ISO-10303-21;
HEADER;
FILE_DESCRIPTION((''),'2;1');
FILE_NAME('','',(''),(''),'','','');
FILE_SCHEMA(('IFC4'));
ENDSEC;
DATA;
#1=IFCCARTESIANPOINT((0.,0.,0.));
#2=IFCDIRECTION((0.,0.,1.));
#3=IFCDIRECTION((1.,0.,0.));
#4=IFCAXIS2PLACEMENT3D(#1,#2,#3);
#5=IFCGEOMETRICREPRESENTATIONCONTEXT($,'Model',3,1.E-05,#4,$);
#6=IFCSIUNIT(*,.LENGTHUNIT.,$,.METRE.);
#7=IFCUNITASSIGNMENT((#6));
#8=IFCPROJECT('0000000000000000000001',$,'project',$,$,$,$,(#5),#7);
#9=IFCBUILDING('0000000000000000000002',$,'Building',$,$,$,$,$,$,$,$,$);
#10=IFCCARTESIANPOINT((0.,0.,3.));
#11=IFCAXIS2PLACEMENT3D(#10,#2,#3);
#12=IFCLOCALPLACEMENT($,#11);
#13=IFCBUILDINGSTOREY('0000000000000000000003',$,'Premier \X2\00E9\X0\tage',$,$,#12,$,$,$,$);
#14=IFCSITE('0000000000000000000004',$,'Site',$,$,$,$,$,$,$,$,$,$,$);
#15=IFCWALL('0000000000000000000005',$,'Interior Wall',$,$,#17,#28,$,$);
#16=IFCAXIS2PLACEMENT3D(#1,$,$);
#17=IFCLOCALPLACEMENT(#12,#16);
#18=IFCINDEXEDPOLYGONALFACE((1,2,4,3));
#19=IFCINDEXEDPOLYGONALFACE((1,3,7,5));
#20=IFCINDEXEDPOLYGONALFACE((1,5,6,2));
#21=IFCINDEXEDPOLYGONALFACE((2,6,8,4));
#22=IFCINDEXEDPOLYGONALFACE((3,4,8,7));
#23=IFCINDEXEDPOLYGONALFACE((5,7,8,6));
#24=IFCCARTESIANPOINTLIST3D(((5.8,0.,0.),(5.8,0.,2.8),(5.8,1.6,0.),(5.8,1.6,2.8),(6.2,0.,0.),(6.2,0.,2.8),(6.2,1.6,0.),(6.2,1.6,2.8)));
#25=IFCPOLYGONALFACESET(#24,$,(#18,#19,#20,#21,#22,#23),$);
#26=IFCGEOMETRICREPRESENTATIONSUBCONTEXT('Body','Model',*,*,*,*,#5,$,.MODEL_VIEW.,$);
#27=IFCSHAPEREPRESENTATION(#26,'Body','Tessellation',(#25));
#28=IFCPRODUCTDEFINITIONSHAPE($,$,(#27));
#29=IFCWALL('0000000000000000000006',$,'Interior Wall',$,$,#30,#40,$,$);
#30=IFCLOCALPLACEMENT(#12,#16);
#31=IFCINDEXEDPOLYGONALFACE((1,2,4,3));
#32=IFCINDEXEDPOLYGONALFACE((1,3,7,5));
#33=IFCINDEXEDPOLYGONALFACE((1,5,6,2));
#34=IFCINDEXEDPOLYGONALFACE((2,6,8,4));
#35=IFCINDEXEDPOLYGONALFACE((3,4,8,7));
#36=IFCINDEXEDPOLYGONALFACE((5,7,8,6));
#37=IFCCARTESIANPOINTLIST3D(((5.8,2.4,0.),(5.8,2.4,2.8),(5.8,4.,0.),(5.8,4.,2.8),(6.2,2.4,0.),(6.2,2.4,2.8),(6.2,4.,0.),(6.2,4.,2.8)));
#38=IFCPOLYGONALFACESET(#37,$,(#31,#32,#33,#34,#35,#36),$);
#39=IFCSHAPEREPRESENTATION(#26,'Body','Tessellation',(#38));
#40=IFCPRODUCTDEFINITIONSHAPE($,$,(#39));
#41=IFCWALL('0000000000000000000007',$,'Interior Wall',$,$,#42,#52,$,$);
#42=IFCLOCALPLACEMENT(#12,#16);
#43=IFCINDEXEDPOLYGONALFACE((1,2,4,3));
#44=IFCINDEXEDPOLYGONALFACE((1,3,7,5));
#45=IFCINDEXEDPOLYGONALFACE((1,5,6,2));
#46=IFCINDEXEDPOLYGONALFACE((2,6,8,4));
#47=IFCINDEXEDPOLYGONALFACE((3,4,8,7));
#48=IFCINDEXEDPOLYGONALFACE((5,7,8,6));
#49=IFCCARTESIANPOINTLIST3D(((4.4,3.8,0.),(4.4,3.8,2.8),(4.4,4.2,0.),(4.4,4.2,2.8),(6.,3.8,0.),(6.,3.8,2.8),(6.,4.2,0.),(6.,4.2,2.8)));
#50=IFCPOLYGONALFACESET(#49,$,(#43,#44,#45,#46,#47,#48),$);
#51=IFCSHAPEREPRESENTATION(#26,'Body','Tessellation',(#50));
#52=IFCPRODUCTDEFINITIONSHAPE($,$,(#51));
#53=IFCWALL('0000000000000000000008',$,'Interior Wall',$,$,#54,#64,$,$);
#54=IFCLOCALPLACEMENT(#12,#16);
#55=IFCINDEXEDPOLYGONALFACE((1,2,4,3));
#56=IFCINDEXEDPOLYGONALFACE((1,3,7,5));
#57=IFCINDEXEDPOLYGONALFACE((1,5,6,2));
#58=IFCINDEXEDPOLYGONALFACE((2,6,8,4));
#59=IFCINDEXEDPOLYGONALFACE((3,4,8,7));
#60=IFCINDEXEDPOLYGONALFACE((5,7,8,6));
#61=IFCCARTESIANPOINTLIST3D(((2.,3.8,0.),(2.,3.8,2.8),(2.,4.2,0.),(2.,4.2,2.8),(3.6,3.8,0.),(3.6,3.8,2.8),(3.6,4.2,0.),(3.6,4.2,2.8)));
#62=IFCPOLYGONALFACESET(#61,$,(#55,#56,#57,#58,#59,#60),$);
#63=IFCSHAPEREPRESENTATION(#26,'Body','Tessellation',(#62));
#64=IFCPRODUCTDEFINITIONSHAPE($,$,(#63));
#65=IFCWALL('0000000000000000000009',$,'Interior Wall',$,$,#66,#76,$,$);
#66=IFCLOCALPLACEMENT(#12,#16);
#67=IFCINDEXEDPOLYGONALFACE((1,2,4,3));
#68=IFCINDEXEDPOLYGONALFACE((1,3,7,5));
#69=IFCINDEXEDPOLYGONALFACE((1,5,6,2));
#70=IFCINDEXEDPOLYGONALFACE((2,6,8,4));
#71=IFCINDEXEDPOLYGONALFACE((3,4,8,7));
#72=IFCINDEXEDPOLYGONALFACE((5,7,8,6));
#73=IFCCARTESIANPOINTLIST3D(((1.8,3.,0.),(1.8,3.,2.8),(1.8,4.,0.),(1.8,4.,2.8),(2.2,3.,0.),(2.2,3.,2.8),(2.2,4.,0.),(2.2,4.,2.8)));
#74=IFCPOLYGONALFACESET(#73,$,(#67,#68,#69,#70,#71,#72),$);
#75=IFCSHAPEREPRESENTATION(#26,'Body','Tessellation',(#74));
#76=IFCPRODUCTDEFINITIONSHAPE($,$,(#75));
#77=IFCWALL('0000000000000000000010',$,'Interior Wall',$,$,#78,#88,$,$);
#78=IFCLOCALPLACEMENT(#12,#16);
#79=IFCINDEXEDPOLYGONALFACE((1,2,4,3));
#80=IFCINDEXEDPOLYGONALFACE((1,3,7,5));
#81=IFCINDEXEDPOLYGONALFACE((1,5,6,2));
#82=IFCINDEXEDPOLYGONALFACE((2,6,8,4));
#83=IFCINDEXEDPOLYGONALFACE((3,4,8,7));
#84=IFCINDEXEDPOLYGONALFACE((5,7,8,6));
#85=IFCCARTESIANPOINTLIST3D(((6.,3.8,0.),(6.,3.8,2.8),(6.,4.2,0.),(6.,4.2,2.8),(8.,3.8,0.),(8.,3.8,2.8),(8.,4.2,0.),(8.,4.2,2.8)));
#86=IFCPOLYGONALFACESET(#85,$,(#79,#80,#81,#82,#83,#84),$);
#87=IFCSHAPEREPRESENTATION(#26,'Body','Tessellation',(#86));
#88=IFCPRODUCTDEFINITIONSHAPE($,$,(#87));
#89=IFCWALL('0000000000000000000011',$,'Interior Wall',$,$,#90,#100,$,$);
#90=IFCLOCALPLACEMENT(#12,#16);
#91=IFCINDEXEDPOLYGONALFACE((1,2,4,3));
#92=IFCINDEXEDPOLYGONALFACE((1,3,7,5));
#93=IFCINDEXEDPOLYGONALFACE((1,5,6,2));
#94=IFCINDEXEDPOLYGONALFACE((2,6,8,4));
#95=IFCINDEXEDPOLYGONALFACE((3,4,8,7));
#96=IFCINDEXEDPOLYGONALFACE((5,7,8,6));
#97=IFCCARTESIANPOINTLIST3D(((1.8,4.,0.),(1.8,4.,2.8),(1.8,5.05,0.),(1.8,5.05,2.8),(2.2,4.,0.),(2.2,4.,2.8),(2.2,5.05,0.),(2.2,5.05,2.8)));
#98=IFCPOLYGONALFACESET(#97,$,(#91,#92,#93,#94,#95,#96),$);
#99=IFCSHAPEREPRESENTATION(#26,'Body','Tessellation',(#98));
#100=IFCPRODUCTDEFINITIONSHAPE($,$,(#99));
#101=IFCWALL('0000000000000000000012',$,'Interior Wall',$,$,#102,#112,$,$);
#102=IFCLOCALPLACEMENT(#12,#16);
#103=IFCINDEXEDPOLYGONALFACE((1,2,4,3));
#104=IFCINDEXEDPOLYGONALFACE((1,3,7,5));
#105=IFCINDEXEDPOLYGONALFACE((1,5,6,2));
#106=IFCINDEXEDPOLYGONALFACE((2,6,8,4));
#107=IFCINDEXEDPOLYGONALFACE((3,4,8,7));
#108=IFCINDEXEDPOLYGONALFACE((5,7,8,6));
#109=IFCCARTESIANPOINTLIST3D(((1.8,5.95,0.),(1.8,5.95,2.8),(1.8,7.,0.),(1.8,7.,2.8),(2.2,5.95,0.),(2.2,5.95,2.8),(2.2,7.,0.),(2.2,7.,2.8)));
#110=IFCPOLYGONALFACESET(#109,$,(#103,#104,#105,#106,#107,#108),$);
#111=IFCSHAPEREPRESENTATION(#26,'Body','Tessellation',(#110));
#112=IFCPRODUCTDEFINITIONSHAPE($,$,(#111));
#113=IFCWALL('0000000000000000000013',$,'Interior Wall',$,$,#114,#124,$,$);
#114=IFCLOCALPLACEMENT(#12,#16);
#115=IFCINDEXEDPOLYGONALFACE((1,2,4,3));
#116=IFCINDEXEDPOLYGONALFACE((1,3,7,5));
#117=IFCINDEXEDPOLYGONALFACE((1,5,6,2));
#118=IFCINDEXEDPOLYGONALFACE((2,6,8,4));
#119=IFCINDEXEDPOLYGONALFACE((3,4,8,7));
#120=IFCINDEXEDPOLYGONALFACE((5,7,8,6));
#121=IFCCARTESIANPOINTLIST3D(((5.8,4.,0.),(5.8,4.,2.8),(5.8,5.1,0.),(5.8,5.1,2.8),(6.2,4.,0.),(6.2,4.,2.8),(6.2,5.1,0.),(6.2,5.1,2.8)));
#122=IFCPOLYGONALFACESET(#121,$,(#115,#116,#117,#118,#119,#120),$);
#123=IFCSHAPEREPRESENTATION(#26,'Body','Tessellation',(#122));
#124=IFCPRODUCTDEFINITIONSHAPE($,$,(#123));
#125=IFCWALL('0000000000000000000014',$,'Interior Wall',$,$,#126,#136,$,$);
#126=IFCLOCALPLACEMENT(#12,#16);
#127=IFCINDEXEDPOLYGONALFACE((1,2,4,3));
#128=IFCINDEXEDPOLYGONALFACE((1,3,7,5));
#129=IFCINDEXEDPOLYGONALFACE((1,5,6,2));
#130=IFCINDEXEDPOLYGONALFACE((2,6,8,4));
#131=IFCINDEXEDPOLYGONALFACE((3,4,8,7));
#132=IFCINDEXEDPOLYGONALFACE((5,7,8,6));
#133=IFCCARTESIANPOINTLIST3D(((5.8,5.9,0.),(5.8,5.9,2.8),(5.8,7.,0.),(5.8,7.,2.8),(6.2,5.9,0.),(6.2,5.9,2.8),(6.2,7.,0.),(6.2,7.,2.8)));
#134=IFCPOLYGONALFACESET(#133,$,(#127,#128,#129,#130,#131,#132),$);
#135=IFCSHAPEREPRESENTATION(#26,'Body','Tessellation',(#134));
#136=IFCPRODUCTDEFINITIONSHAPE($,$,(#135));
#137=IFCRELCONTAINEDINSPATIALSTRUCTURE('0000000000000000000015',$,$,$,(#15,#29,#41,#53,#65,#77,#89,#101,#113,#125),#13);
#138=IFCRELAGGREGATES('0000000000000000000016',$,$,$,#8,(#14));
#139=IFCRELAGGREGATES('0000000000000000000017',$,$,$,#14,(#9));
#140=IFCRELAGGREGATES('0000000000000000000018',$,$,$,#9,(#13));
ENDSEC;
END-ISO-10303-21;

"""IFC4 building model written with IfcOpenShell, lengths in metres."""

from ifc_helpers import new_model, si_unit, frame, origin_with_axes, place, context, subcontext, project, spatial, indexed_curve, outline, extrude, element, save


model = new_model("IFC4")

# Units and contexts
model_context = context("Model", 3, precision=1e-05, world=origin_with_axes())
body_context = subcontext(model_context, "Body", "Model", "MODEL_VIEW")
ifc_project = project(units=[si_unit("LENGTHUNIT", "METRE")], contexts=[model_context])

# Site, building, storey
site = spatial("IfcSite", under=ifc_project, Name="Site")
building = spatial("IfcBuilding", under=site, Name="Building")
storey_placement = place(None, frame((0.0, 0.0, 3.0), z_axis=(0.0, 0.0, 1.0), x_axis=(1.0, 0.0, 0.0)))
storey = spatial("IfcBuildingStorey", under=building, at=storey_placement, Name="Premier étage")

# Walls
for number, where, z_axis, x_axis, name in (
    (1, (6.0, 0.0, 0.0), (0.0, 0.0, 1.0), (0.0, 1.0, 0.0), "Interior Wall"),
    (2, (6.0, 2.4, 0.0), (0.0, 0.0, 1.0), (0.0, 1.0, 0.0), "Interior Wall"),
):
    element("IfcWall", number, at=place(storey_placement, frame(where, z_axis=z_axis, x_axis=x_axis)), inside=storey, Name=name, context=body_context, shape_type="SweptSolid", body=[
        extrude(outline(indexed_curve([(0.0, 0.0), (0.0, 0.4), (1.6, 0.4), (1.6, 0.0), (0.0, 0.0)], self_intersect=False)), frame((0.0, -0.2, 0.0), z_axis=(0.0, 0.0, 1.0), x_axis=(1.0, 0.0, 0.0)), (0.0, 0.0, 1.0), 2.8),
    ])
wall_1_placement = place(storey_placement, frame((6.0, 4.0, 0.0), z_axis=(0.0, 0.0, 1.0), x_axis=(-1.0, 0.0, 0.0)))
element("IfcWall", 3, at=wall_1_placement, inside=storey, Name="Interior Wall", context=body_context, shape_type="SweptSolid", body=[
    extrude(outline(indexed_curve([(0.0, 0.0), (0.0, 0.4), (1.6, 0.4), (1.6, 0.0), (0.0, 0.0)], self_intersect=False)), frame((0.0, -0.2, 0.0), z_axis=(0.0, 0.0, 1.0), x_axis=(1.0, 0.0, 0.0)), (0.0, 0.0, 1.0), 2.8),
])
wall_2_placement = place(storey_placement, frame((3.6, 4.0, 0.0), z_axis=(0.0, 0.0, 1.0), x_axis=(-1.0, 0.0, 0.0)))
element("IfcWall", 4, at=wall_2_placement, inside=storey, Name="Interior Wall", context=body_context, shape_type="SweptSolid", body=[
    extrude(outline(indexed_curve([(0.0, 0.0), (0.0, 0.4), (1.6, 0.4), (1.6, 0.0), (0.0, 0.0)], self_intersect=False)), frame((0.0, -0.2, 0.0), z_axis=(0.0, 0.0, 1.0), x_axis=(1.0, 0.0, 0.0)), (0.0, 0.0, 1.0), 2.8),
])
wall_3_placement = place(storey_placement, frame((2.0, 4.0, 0.0), z_axis=(0.0, 0.0, 1.0), x_axis=(0.0, -1.0, 0.0)))
element("IfcWall", 5, at=wall_3_placement, inside=storey, Name="Interior Wall", context=body_context, shape_type="SweptSolid", body=[
    extrude(outline(indexed_curve([(0.0, 0.0), (0.0, 0.4), (1.0, 0.4), (1.0, 0.0), (0.0, 0.0)], self_intersect=False)), frame((0.0, -0.2, 0.0), z_axis=(0.0, 0.0, 1.0), x_axis=(1.0, 0.0, 0.0)), (0.0, 0.0, 1.0), 2.8),
])
wall_4_placement = place(storey_placement, frame((8.0, 4.0, 0.0), z_axis=(0.0, 0.0, 1.0), x_axis=(-1.0, 0.0, 0.0)))
element("IfcWall", 6, at=wall_4_placement, inside=storey, Name="Interior Wall", context=body_context, shape_type="SweptSolid", body=[
    extrude(outline(indexed_curve([(0.0, 0.0), (0.0, 0.4), (2.0, 0.4), (2.0, 0.0), (0.0, 0.0)], self_intersect=False)), frame((0.0, -0.2, 0.0), z_axis=(0.0, 0.0, 1.0), x_axis=(1.0, 0.0, 0.0)), (0.0, 0.0, 1.0), 2.8),
])
for number, where, z_axis, x_axis, name in (
    (7, (2.0, 4.0, 0.0), (0.0, 0.0, 1.0), (0.0, 1.0, 0.0), "Interior Wall"),
    (8, (2.0, 5.95, 0.0), (0.0, 0.0, 1.0), (0.0, 1.0, 0.0), "Interior Wall"),
):
    element("IfcWall", number, at=place(storey_placement, frame(where, z_axis=z_axis, x_axis=x_axis)), inside=storey, Name=name, context=body_context, shape_type="SweptSolid", body=[
        extrude(outline(indexed_curve([(0.0, 0.0), (0.0, 0.4), (1.05, 0.4), (1.05, 0.0), (0.0, 0.0)], self_intersect=False)), frame((0.0, -0.2, 0.0), z_axis=(0.0, 0.0, 1.0), x_axis=(1.0, 0.0, 0.0)), (0.0, 0.0, 1.0), 2.8),
    ])
for number, where, z_axis, x_axis, name in (
    (9, (6.0, 4.0, 0.0), (0.0, 0.0, 1.0), (0.0, 1.0, 0.0), "Interior Wall"),
    (10, (6.0, 5.9, 0.0), (0.0, 0.0, 1.0), (0.0, 1.0, 0.0), "Interior Wall"),
):
    element("IfcWall", number, at=place(storey_placement, frame(where, z_axis=z_axis, x_axis=x_axis)), inside=storey, Name=name, context=body_context, shape_type="SweptSolid", body=[
        extrude(outline(indexed_curve([(0.0, 0.0), (0.0, 0.4), (1.1, 0.4), (1.1, 0.0), (0.0, 0.0)], self_intersect=False)), frame((0.0, -0.2, 0.0), z_axis=(0.0, 0.0, 1.0), x_axis=(1.0, 0.0, 0.0)), (0.0, 0.0, 1.0), 2.8),
    ])

save(model, "model.ifc")
